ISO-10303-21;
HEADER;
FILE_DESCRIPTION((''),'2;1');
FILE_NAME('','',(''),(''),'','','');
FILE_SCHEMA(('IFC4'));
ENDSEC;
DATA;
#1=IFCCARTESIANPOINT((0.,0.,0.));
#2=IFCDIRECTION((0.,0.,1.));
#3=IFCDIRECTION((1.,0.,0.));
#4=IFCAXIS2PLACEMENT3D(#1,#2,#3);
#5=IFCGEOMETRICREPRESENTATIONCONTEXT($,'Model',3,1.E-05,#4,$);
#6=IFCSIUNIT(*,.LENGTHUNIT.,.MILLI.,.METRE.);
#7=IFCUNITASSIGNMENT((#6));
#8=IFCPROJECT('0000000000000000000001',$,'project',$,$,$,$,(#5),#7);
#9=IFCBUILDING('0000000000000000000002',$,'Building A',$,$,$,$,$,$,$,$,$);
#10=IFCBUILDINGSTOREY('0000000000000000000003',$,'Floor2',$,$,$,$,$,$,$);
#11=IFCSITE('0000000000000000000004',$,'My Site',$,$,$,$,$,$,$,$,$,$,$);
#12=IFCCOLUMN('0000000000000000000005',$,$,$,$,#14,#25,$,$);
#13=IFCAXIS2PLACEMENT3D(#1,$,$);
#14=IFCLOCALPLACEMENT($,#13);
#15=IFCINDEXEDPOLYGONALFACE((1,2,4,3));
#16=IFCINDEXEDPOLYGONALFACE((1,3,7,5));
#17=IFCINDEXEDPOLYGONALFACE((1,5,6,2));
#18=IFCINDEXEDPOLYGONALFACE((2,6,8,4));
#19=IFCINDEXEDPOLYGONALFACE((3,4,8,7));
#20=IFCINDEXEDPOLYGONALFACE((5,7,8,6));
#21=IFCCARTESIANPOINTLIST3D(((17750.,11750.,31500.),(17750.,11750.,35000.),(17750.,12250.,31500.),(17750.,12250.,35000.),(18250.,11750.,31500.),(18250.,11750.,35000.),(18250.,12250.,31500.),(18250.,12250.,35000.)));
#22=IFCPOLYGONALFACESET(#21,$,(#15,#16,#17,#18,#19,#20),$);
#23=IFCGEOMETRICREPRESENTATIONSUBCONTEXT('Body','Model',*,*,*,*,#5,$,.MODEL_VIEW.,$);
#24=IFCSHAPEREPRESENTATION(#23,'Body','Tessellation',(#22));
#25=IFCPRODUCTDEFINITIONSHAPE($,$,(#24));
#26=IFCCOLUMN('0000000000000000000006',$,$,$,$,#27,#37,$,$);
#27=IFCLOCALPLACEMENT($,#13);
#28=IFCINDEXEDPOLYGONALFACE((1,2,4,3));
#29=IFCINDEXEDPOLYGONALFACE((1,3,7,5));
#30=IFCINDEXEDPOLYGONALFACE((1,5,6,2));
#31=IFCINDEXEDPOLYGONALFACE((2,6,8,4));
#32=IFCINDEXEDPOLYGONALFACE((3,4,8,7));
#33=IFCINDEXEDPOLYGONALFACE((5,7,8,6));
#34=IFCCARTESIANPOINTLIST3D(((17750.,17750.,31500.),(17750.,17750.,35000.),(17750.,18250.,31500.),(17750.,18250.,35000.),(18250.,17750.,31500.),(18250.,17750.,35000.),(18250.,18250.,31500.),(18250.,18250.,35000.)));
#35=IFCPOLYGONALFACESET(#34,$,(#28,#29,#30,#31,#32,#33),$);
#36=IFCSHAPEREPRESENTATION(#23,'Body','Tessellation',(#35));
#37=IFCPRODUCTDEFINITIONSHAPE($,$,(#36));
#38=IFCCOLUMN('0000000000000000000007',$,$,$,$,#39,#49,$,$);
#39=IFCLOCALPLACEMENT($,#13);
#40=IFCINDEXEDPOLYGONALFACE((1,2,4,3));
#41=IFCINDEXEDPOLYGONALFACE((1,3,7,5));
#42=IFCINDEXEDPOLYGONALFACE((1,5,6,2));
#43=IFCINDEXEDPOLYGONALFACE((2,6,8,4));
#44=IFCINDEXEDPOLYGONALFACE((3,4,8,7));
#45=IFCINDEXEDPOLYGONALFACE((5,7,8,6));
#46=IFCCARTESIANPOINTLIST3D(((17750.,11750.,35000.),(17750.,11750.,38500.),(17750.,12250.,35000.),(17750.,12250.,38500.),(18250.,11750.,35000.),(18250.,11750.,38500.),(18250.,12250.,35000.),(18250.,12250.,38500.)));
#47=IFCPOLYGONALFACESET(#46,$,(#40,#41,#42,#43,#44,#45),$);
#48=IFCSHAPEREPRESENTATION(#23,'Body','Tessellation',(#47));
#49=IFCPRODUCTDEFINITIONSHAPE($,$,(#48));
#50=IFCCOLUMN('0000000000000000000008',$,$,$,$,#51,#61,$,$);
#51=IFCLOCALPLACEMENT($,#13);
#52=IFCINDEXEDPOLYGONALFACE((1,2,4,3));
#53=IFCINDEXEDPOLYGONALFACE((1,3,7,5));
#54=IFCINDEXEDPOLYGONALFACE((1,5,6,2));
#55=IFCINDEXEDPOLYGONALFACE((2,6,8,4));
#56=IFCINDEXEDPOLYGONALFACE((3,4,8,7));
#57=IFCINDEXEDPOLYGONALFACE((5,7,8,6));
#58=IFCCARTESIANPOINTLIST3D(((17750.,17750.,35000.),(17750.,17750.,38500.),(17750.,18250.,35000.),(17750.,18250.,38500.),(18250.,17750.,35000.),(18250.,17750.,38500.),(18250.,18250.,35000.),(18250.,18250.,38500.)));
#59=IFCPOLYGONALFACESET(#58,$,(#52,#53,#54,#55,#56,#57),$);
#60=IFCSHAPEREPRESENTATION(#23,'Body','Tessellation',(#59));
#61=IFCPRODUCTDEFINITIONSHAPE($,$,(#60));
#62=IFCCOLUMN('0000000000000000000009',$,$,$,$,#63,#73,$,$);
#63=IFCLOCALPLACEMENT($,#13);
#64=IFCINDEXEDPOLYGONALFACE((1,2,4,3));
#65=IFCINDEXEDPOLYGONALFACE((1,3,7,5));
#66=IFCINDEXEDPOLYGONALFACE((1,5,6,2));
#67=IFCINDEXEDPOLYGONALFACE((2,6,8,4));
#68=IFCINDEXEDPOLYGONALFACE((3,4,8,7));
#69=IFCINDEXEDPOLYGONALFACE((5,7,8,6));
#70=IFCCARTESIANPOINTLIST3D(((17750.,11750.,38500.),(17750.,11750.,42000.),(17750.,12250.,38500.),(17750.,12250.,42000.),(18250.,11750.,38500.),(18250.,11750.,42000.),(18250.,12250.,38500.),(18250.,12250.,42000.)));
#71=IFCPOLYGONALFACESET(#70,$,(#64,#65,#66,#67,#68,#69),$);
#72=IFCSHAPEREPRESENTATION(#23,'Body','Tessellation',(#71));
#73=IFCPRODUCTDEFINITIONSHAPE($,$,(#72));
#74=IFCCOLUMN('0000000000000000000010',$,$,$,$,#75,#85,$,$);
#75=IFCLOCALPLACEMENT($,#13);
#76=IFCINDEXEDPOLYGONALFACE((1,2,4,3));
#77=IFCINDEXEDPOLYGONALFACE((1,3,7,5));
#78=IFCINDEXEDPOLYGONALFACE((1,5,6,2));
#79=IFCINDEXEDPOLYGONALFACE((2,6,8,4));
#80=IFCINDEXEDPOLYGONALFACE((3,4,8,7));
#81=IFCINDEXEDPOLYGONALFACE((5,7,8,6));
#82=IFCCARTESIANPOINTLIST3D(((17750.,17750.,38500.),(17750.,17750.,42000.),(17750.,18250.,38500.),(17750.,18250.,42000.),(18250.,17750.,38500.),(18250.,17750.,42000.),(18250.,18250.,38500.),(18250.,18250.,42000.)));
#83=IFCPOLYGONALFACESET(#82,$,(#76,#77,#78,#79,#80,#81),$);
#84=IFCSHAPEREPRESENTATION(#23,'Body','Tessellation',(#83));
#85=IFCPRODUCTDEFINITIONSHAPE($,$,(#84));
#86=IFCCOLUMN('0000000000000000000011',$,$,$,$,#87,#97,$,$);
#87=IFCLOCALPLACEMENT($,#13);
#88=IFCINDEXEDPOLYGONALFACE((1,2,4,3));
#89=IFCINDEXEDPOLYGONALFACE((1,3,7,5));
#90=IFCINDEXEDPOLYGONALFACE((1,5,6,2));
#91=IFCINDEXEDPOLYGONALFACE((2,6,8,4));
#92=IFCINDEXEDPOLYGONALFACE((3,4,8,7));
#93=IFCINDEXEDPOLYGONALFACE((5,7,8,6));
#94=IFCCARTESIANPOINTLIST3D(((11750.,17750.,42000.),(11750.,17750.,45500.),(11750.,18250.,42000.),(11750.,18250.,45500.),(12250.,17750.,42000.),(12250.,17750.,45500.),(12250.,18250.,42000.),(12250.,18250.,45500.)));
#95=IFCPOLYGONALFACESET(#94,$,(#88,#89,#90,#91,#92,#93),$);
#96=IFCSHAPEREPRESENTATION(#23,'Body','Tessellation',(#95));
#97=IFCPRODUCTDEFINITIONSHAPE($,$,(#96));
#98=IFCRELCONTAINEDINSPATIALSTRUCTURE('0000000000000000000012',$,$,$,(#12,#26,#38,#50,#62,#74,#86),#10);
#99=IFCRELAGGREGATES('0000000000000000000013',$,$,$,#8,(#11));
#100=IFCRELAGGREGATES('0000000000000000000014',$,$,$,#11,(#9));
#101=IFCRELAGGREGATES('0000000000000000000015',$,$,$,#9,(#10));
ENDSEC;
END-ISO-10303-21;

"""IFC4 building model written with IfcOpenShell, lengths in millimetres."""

from ifc_helpers import new_model, si_unit, frame, origin_with_axes, place, context, subcontext, project, spatial, line, indexed_curve, outline, extrude, element, save


model = new_model("IFC4")

# Units and contexts
model_context = context("Model", 3, precision=1e-05, world=origin_with_axes())
body_context = subcontext(model_context, "Body", "Model", "MODEL_VIEW")
ifc_project = project(units=[si_unit("LENGTHUNIT", "METRE", prefix="MILLI")], contexts=[model_context])

# Site, building, storey
site = spatial("IfcSite", under=ifc_project, Name="My Site")
building = spatial("IfcBuilding", under=site, Name="Building A")
storey = spatial("IfcBuildingStorey", under=building, Name="Floor2")

# Columns
for number, where, z_axis, x_axis in (
    (1, (18000.0, 12000.0, 31500.0), (0.0, 0.0, 1.0), (1.0, 0.0, 0.0)),
    (2, (18000.0, 18000.0, 31500.0), (0.0, 0.0, 1.0), (1.0, 0.0, 0.0)),
    (3, (18000.0, 12000.0, 35000.0), (0.0, 0.0, 1.0), (1.0, 0.0, 0.0)),
    (4, (18000.0, 18000.0, 35000.0), (0.0, 0.0, 1.0), (1.0, 0.0, 0.0)),
    (5, (18000.0, 12000.0, 38500.0), (0.0, 0.0, 1.0), (1.0, 0.0, 0.0)),
    (6, (18000.0, 18000.0, 38500.0), (0.0, 0.0, 1.0), (1.0, 0.0, 0.0)),
    (7, (12000.0, 18000.0, 42000.0), (0.0, 0.0, 1.0), (1.0, 0.0, 0.0)),
):
    element("IfcColumn", number, at=place(None, frame(where, z_axis=z_axis, x_axis=x_axis)), inside=storey, context=body_context, shape_type="SweptSolid", body=[
        extrude(outline(indexed_curve([(-250.0, -250.0), (250.0, -250.0), (250.0, 250.0), (-250.0, 250.0)], segments=[line(1, 2, 3, 4, 1)])), origin_with_axes(), (0.0, 0.0, 1.0), 3500.0),
    ])

save(model, "model.ifc")
